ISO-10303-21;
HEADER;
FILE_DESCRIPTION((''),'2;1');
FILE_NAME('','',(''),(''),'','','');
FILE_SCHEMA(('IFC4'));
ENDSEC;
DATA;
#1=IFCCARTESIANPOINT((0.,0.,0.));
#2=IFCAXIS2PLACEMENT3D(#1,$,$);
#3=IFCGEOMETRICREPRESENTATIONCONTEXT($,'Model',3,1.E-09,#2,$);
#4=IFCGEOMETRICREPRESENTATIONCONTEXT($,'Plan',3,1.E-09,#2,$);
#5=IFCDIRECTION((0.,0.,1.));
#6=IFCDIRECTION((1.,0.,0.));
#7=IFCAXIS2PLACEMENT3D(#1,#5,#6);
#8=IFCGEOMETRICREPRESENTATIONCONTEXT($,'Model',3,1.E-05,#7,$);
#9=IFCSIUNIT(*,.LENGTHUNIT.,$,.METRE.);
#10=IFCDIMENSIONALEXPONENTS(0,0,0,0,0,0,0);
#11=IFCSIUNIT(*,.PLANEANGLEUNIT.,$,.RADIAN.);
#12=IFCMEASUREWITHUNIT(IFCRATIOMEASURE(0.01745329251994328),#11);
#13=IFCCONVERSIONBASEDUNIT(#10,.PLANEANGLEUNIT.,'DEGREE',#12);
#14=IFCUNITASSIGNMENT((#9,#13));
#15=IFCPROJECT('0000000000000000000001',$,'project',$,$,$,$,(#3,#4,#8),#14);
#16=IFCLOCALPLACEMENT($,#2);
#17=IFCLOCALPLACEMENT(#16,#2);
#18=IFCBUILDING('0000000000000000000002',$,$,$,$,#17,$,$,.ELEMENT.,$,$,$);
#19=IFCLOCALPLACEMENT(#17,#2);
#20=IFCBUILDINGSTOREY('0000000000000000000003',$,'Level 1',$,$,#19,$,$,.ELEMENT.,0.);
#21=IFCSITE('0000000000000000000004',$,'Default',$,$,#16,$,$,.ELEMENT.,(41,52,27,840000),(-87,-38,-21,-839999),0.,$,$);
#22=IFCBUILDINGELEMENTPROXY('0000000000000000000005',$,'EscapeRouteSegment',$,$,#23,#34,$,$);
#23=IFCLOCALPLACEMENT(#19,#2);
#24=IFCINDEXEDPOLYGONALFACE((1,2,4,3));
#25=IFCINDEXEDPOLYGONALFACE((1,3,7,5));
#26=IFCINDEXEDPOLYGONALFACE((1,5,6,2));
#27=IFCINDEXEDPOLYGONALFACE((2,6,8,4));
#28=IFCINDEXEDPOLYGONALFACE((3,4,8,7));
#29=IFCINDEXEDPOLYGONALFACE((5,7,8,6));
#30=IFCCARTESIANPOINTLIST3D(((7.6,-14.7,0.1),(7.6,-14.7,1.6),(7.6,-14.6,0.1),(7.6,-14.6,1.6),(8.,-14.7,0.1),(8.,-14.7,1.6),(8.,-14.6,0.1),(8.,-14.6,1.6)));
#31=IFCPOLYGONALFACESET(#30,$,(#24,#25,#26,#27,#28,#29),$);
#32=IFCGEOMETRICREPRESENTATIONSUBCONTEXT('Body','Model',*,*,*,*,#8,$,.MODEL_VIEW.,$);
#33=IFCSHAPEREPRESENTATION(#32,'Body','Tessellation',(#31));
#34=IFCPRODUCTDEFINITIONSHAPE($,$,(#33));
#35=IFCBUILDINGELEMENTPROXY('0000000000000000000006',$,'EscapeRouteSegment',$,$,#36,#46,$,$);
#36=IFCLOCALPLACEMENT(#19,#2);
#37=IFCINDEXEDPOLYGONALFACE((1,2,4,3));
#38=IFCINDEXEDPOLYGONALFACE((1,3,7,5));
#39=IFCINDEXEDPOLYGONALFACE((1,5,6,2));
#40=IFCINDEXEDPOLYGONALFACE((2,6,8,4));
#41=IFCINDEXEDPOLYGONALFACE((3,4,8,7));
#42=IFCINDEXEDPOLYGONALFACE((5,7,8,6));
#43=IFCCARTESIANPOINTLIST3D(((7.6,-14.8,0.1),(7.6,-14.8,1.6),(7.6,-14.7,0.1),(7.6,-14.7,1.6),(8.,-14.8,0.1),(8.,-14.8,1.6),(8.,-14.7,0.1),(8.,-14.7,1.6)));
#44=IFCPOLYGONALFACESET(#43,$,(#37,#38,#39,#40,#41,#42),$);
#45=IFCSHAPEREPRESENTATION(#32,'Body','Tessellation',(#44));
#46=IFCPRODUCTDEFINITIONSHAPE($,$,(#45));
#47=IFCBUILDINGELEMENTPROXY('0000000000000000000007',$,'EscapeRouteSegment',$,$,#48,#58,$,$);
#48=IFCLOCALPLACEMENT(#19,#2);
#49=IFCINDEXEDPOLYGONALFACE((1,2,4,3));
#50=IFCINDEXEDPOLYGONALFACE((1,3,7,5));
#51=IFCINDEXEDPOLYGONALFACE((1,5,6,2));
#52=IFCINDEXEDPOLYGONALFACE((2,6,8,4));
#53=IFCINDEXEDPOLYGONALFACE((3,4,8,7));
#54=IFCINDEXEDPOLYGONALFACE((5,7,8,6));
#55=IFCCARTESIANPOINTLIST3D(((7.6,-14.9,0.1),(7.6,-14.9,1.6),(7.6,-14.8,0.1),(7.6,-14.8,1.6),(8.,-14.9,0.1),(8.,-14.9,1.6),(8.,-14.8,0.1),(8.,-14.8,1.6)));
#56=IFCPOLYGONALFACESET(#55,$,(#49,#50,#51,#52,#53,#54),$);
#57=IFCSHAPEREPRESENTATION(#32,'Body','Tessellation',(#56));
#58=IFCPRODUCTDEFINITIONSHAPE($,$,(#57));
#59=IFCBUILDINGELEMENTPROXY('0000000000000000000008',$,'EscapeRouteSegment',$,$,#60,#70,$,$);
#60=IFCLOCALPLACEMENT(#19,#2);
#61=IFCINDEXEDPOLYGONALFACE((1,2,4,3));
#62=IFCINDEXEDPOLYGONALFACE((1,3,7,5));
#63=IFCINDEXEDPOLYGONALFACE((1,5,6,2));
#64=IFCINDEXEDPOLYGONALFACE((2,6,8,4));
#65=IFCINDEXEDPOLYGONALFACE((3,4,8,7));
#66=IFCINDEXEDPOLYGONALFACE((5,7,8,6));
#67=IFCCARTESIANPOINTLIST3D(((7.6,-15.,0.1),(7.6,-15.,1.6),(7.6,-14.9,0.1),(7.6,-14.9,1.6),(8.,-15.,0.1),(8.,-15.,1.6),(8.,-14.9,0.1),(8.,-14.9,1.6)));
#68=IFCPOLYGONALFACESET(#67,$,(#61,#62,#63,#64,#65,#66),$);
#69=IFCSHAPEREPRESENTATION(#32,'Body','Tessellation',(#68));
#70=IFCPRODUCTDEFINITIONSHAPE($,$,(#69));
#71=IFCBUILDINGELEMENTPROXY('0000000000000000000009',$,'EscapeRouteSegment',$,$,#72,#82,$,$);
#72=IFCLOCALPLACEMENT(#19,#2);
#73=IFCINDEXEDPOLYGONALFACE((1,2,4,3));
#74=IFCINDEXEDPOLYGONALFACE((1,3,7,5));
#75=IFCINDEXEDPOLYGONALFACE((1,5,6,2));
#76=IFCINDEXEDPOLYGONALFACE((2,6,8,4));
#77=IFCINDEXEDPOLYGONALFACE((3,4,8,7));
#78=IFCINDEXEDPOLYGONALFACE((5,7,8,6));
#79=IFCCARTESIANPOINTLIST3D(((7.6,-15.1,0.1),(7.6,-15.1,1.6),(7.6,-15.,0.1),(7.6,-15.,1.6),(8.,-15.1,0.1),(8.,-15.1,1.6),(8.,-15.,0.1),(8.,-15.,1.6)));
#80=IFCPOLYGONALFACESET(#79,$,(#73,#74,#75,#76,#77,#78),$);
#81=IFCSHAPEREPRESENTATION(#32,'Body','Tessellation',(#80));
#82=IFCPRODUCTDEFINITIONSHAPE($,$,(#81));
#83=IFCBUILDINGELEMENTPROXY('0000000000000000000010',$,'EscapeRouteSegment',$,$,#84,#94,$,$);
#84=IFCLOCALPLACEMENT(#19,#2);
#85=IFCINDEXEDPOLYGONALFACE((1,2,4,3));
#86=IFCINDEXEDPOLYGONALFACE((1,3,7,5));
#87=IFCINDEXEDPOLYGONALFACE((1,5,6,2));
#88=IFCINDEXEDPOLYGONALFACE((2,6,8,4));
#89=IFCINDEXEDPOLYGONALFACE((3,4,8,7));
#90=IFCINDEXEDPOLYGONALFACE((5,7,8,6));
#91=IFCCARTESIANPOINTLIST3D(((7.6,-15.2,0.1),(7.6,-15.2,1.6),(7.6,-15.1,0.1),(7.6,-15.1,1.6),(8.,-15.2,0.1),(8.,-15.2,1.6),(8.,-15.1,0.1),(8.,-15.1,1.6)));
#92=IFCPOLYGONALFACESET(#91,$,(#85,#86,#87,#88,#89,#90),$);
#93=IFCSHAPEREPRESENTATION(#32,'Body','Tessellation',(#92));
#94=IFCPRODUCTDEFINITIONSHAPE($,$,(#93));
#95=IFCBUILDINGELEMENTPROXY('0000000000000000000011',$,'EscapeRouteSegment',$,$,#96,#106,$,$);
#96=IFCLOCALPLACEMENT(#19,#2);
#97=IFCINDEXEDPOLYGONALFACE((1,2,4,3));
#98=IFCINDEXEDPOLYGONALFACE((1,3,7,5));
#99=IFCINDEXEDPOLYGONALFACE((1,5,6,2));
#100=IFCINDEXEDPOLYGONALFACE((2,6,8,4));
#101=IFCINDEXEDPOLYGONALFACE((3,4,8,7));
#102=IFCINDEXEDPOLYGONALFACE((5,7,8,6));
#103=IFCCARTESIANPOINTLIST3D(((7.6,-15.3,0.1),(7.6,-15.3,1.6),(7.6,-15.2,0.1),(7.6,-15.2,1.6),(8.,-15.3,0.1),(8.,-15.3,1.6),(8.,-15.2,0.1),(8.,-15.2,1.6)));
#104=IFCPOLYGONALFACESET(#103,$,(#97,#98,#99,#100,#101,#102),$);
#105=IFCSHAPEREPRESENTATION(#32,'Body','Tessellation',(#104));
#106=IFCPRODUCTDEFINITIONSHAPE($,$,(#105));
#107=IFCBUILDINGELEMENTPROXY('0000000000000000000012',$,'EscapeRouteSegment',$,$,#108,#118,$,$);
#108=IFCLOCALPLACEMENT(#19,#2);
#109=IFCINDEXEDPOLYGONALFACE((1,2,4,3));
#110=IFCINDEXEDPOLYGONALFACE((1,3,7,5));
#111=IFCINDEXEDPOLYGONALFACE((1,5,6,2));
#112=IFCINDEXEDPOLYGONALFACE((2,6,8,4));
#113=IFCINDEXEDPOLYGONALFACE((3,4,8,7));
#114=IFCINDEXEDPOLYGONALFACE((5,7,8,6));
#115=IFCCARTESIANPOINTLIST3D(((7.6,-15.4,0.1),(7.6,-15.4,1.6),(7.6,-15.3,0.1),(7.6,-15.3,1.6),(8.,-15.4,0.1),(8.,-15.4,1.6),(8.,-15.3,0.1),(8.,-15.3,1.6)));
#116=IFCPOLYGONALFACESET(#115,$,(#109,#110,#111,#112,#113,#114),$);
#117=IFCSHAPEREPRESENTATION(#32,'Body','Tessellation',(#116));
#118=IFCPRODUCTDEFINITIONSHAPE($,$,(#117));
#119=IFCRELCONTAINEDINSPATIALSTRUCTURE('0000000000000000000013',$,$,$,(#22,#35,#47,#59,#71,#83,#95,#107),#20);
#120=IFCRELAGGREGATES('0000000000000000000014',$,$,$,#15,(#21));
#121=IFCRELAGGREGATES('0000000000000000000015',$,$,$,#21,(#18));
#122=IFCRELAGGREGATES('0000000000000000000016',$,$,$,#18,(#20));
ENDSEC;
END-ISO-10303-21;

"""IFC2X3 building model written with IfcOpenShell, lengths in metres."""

from ifc_helpers import new_model, entity, si_unit, converted_unit, frame, origin, origin_with_axes, place, context, subcontext, project, spatial, polyline, outline, extrude, element, save


model = new_model("IFC2X3")

# Units and contexts
model_context_1 = context("Model", 3, precision=1e-09, world=origin())
plan_context = context("Plan", 3, precision=1e-09, world=origin())
model_context_2 = context("Model", 3, precision=1e-05, world=origin_with_axes())
body_context = subcontext(model_context_2, "Body", "Model", "MODEL_VIEW")
ifc_project = project(units=[si_unit("LENGTHUNIT", "METRE"), converted_unit("PLANEANGLEUNIT", "DEGREE", entity("IfcRatioMeasure", 0.01745329251994328), si_unit("PLANEANGLEUNIT", "RADIAN"), dimensions=[0, 0, 0, 0, 0, 0, 0])], contexts=[model_context_1, plan_context, model_context_2])

# Site, building, storey
site_placement = place(None, origin())
site = spatial("IfcSite", under=ifc_project, at=site_placement, Name="Default", CompositionType="ELEMENT", RefLatitude=(41, 52, 27, 840000), RefLongitude=(-87, -38, -21, -839999), RefElevation=0.0)
building_placement = place(site_placement, origin())
building = spatial("IfcBuilding", under=site, at=building_placement, CompositionType="ELEMENT")
storey_placement = place(building_placement, origin())
storey = spatial("IfcBuildingStorey", under=building, at=storey_placement, Name="Level 1", CompositionType="ELEMENT", Elevation=0.0)

# Building element proxies
proxy_1_placement = place(storey_placement, frame((7.8, -14.6, 0.1), z_axis=(0.0, 0.0, 1.0), x_axis=(0.0, -1.0, 0.0)))
element("IfcBuildingElementProxy", 1, at=proxy_1_placement, inside=storey, Name="EscapeRouteSegment", context=body_context, shape_type="SweptSolid", body=[
    extrude(outline(polyline([(0.0, -0.2), (0.0, 0.2), (0.1, 0.2), (0.1, -0.2), (0.0, -0.2)])), origin_with_axes(), (0.0, 0.0, 1.0), 1.5),
])
proxy_2_placement = place(storey_placement, frame((7.8, -14.7, 0.1), z_axis=(0.0, 0.0, 1.0), x_axis=(0.0, -1.0, 0.0)))
element("IfcBuildingElementProxy", 2, at=proxy_2_placement, inside=storey, Name="EscapeRouteSegment", context=body_context, shape_type="SweptSolid", body=[
    extrude(outline(polyline([(0.0, -0.2), (0.0, 0.2), (0.1, 0.2), (0.1, -0.2), (0.0, -0.2)])), origin_with_axes(), (0.0, 0.0, 1.0), 1.5),
])
proxy_3_placement = place(storey_placement, frame((7.8, -14.8, 0.1), z_axis=(0.0, 0.0, 1.0), x_axis=(0.0, -1.0, 0.0)))
element("IfcBuildingElementProxy", 3, at=proxy_3_placement, inside=storey, Name="EscapeRouteSegment", context=body_context, shape_type="SweptSolid", body=[
    extrude(outline(polyline([(0.0, -0.2), (0.0, 0.2), (0.1, 0.2), (0.1, -0.2), (0.0, -0.2)])), origin_with_axes(), (0.0, 0.0, 1.0), 1.5),
])
for number, where, z_axis, x_axis, name in (
    (4, (7.8, -14.9, 0.1), (0.0, 0.0, 1.0), (0.0, -1.0, 0.0), "EscapeRouteSegment"),
    (5, (7.8, -15.0, 0.1), (0.0, 0.0, 1.0), (0.0, -1.0, 0.0), "EscapeRouteSegment"),
):
    element("IfcBuildingElementProxy", number, at=place(storey_placement, frame(where, z_axis=z_axis, x_axis=x_axis)), inside=storey, Name=name, context=body_context, shape_type="SweptSolid", body=[
        extrude(outline(polyline([(0.0, -0.2), (0.0, 0.2), (0.1, 0.2), (0.1, -0.2), (0.0, -0.2)])), origin_with_axes(), (0.0, 0.0, 1.0), 1.5),
    ])
proxy_4_placement = place(storey_placement, frame((7.8, -15.1, 0.1), z_axis=(0.0, 0.0, 1.0), x_axis=(0.0, -1.0, 0.0)))
element("IfcBuildingElementProxy", 6, at=proxy_4_placement, inside=storey, Name="EscapeRouteSegment", context=body_context, shape_type="SweptSolid", body=[
    extrude(outline(polyline([(0.0, -0.2), (0.0, 0.2), (0.1, 0.2), (0.1, -0.2), (0.0, -0.2)])), origin_with_axes(), (0.0, 0.0, 1.0), 1.5),
])
proxy_5_placement = place(storey_placement, frame((7.8, -15.2, 0.1), z_axis=(0.0, 0.0, 1.0), x_axis=(0.0, -1.0, 0.0)))
element("IfcBuildingElementProxy", 7, at=proxy_5_placement, inside=storey, Name="EscapeRouteSegment", context=body_context, shape_type="SweptSolid", body=[
    extrude(outline(polyline([(0.0, -0.2), (0.0, 0.2), (0.1, 0.2), (0.1, -0.2), (0.0, -0.2)])), origin_with_axes(), (0.0, 0.0, 1.0), 1.5),
])
for number, where, z_axis, x_axis, name in (
    (8, (7.8, -15.3, 0.1), (0.0, 0.0, 1.0), (0.0, -1.0, 0.0), "EscapeRouteSegment"),
):
    element("IfcBuildingElementProxy", number, at=place(storey_placement, frame(where, z_axis=z_axis, x_axis=x_axis)), inside=storey, Name=name, context=body_context, shape_type="SweptSolid", body=[
        extrude(outline(polyline([(0.0, -0.2), (0.0, 0.2), (0.1, 0.2), (0.1, -0.2), (0.0, -0.2)])), origin_with_axes(), (0.0, 0.0, 1.0), 1.5),
    ])

save(model, "model.ifc")
